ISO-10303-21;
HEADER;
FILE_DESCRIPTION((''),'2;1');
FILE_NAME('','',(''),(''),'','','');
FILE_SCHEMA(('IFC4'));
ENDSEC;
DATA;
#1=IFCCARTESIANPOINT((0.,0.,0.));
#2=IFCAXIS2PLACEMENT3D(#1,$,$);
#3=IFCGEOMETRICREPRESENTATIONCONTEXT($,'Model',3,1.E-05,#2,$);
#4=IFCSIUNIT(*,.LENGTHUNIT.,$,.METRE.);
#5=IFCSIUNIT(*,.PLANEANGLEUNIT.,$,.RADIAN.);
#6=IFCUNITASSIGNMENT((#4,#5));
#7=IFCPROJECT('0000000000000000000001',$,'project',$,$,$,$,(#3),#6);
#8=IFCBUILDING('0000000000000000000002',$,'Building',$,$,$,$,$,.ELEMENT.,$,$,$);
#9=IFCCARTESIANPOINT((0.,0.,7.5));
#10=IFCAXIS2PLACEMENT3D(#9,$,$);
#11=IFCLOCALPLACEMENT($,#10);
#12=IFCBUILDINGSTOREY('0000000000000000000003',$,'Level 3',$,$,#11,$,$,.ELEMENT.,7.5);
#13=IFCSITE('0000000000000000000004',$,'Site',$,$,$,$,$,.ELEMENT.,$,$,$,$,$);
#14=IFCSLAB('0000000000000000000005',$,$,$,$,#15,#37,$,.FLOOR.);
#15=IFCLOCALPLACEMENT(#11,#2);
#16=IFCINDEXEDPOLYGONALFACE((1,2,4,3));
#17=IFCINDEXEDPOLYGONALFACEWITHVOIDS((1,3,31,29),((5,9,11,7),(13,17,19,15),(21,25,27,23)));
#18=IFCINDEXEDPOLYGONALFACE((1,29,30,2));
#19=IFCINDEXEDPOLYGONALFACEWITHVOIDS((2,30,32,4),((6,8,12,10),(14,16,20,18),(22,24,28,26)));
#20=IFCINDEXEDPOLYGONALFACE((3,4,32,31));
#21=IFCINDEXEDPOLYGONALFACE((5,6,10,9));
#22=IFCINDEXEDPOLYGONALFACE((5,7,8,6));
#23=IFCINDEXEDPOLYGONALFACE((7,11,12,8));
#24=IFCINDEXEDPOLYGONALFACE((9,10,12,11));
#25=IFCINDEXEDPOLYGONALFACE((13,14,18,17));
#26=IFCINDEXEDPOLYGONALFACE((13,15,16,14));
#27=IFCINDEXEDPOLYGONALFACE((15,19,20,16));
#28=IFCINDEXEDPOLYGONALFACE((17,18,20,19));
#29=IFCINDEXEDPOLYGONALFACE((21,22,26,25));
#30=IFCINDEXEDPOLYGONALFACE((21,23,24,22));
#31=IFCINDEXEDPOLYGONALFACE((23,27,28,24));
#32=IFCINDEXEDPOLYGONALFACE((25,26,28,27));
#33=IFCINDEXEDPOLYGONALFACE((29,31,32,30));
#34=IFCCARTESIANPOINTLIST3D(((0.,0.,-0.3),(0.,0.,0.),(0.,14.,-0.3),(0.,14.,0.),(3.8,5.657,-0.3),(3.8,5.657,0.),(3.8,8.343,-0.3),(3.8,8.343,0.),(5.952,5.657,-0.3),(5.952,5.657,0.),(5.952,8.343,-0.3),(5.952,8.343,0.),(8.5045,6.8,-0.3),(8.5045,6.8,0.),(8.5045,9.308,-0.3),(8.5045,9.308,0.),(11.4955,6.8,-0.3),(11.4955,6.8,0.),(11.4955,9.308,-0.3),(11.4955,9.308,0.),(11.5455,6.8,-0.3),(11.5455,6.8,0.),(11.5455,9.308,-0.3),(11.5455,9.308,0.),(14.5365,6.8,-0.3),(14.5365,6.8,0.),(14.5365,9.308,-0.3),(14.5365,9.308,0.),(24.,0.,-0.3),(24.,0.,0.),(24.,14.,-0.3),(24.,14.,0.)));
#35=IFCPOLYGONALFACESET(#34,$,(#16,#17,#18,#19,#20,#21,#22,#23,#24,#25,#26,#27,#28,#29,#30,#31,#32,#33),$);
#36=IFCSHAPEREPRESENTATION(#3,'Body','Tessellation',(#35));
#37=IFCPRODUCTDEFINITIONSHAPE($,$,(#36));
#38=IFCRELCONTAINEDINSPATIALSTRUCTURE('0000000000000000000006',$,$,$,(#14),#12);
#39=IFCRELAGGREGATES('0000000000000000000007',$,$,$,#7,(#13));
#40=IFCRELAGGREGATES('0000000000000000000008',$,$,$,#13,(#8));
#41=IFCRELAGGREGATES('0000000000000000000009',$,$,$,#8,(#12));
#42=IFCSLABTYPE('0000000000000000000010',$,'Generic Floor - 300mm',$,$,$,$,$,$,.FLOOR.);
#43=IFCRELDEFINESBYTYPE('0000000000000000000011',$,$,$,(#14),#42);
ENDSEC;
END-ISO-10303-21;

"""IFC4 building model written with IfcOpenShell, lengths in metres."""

from ifc_helpers import new_model, si_unit, frame, origin, place, context, project, spatial, polyline, outline, extrude, type_object, element, save


model = new_model("IFC4")

# Units and contexts
model_context = context("Model", 3, precision=1e-05, world=origin())
ifc_project = project(units=[si_unit("LENGTHUNIT", "METRE"), si_unit("PLANEANGLEUNIT", "RADIAN")], contexts=[model_context])

# Site, building, storey
site = spatial("IfcSite", under=ifc_project, Name="Site", CompositionType="ELEMENT")
building = spatial("IfcBuilding", under=site, Name="Building", CompositionType="ELEMENT")
storey_placement = place(None, frame((0.0, 0.0, 7.5)))
storey = spatial("IfcBuildingStorey", under=building, at=storey_placement, Name="Level 3", CompositionType="ELEMENT", Elevation=7.5)

# Slab, openings
slab_type = type_object("IfcSlabType", Name="Generic Floor - 300mm", PredefinedType="FLOOR")
slab_placement = place(None, frame((0.0, 0.0, 7.5)))
slab = element("IfcSlab", 1, at=slab_placement, inside=storey, type_object=slab_type, PredefinedType="FLOOR", context=model_context, shape_type="SweptSolid", body=[
    extrude(outline(polyline([(0.0, 0.0), (24.0, 0.0), (24.0, 14.0), (0.0, 14.0), (0.0, 0.0)])), origin(), (0.0, 0.0, -1.0), 0.3),
])
opening_1_placement = place(None, frame((0.0, 0.0, 7.501)))
element("IfcOpeningElement", 2, at=opening_1_placement, cuts=slab, PredefinedType="OPENING", context=model_context, shape_type="SweptSolid", body=[
    extrude(outline(polyline([(8.5045, 6.8), (11.4955, 6.8), (11.4955, 9.308), (8.5045, 9.308), (8.5045, 6.8)])), origin(), (0.0, 0.0, -1.0), 0.302),
])
opening_2_placement = place(None, frame((0.0, 0.0, 7.501)))
element("IfcOpeningElement", 3, at=opening_2_placement, cuts=slab, PredefinedType="OPENING", context=model_context, shape_type="SweptSolid", body=[
    extrude(outline(polyline([(11.5455, 6.8), (14.5365, 6.8), (14.5365, 9.308), (11.5455, 9.308), (11.5455, 6.8)])), origin(), (0.0, 0.0, -1.0), 0.302),
])
opening_3_placement = place(None, frame((0.0, 0.0, 7.501)))
element("IfcOpeningElement", 4, at=opening_3_placement, cuts=slab, PredefinedType="OPENING", context=model_context, shape_type="SweptSolid", body=[
    extrude(outline(polyline([(3.8, 8.343), (3.8, 5.657), (5.952, 5.657), (5.952, 8.343), (3.8, 8.343)])), origin(), (0.0, 0.0, -1.0), 0.302),
])

save(model, "model.ifc")
